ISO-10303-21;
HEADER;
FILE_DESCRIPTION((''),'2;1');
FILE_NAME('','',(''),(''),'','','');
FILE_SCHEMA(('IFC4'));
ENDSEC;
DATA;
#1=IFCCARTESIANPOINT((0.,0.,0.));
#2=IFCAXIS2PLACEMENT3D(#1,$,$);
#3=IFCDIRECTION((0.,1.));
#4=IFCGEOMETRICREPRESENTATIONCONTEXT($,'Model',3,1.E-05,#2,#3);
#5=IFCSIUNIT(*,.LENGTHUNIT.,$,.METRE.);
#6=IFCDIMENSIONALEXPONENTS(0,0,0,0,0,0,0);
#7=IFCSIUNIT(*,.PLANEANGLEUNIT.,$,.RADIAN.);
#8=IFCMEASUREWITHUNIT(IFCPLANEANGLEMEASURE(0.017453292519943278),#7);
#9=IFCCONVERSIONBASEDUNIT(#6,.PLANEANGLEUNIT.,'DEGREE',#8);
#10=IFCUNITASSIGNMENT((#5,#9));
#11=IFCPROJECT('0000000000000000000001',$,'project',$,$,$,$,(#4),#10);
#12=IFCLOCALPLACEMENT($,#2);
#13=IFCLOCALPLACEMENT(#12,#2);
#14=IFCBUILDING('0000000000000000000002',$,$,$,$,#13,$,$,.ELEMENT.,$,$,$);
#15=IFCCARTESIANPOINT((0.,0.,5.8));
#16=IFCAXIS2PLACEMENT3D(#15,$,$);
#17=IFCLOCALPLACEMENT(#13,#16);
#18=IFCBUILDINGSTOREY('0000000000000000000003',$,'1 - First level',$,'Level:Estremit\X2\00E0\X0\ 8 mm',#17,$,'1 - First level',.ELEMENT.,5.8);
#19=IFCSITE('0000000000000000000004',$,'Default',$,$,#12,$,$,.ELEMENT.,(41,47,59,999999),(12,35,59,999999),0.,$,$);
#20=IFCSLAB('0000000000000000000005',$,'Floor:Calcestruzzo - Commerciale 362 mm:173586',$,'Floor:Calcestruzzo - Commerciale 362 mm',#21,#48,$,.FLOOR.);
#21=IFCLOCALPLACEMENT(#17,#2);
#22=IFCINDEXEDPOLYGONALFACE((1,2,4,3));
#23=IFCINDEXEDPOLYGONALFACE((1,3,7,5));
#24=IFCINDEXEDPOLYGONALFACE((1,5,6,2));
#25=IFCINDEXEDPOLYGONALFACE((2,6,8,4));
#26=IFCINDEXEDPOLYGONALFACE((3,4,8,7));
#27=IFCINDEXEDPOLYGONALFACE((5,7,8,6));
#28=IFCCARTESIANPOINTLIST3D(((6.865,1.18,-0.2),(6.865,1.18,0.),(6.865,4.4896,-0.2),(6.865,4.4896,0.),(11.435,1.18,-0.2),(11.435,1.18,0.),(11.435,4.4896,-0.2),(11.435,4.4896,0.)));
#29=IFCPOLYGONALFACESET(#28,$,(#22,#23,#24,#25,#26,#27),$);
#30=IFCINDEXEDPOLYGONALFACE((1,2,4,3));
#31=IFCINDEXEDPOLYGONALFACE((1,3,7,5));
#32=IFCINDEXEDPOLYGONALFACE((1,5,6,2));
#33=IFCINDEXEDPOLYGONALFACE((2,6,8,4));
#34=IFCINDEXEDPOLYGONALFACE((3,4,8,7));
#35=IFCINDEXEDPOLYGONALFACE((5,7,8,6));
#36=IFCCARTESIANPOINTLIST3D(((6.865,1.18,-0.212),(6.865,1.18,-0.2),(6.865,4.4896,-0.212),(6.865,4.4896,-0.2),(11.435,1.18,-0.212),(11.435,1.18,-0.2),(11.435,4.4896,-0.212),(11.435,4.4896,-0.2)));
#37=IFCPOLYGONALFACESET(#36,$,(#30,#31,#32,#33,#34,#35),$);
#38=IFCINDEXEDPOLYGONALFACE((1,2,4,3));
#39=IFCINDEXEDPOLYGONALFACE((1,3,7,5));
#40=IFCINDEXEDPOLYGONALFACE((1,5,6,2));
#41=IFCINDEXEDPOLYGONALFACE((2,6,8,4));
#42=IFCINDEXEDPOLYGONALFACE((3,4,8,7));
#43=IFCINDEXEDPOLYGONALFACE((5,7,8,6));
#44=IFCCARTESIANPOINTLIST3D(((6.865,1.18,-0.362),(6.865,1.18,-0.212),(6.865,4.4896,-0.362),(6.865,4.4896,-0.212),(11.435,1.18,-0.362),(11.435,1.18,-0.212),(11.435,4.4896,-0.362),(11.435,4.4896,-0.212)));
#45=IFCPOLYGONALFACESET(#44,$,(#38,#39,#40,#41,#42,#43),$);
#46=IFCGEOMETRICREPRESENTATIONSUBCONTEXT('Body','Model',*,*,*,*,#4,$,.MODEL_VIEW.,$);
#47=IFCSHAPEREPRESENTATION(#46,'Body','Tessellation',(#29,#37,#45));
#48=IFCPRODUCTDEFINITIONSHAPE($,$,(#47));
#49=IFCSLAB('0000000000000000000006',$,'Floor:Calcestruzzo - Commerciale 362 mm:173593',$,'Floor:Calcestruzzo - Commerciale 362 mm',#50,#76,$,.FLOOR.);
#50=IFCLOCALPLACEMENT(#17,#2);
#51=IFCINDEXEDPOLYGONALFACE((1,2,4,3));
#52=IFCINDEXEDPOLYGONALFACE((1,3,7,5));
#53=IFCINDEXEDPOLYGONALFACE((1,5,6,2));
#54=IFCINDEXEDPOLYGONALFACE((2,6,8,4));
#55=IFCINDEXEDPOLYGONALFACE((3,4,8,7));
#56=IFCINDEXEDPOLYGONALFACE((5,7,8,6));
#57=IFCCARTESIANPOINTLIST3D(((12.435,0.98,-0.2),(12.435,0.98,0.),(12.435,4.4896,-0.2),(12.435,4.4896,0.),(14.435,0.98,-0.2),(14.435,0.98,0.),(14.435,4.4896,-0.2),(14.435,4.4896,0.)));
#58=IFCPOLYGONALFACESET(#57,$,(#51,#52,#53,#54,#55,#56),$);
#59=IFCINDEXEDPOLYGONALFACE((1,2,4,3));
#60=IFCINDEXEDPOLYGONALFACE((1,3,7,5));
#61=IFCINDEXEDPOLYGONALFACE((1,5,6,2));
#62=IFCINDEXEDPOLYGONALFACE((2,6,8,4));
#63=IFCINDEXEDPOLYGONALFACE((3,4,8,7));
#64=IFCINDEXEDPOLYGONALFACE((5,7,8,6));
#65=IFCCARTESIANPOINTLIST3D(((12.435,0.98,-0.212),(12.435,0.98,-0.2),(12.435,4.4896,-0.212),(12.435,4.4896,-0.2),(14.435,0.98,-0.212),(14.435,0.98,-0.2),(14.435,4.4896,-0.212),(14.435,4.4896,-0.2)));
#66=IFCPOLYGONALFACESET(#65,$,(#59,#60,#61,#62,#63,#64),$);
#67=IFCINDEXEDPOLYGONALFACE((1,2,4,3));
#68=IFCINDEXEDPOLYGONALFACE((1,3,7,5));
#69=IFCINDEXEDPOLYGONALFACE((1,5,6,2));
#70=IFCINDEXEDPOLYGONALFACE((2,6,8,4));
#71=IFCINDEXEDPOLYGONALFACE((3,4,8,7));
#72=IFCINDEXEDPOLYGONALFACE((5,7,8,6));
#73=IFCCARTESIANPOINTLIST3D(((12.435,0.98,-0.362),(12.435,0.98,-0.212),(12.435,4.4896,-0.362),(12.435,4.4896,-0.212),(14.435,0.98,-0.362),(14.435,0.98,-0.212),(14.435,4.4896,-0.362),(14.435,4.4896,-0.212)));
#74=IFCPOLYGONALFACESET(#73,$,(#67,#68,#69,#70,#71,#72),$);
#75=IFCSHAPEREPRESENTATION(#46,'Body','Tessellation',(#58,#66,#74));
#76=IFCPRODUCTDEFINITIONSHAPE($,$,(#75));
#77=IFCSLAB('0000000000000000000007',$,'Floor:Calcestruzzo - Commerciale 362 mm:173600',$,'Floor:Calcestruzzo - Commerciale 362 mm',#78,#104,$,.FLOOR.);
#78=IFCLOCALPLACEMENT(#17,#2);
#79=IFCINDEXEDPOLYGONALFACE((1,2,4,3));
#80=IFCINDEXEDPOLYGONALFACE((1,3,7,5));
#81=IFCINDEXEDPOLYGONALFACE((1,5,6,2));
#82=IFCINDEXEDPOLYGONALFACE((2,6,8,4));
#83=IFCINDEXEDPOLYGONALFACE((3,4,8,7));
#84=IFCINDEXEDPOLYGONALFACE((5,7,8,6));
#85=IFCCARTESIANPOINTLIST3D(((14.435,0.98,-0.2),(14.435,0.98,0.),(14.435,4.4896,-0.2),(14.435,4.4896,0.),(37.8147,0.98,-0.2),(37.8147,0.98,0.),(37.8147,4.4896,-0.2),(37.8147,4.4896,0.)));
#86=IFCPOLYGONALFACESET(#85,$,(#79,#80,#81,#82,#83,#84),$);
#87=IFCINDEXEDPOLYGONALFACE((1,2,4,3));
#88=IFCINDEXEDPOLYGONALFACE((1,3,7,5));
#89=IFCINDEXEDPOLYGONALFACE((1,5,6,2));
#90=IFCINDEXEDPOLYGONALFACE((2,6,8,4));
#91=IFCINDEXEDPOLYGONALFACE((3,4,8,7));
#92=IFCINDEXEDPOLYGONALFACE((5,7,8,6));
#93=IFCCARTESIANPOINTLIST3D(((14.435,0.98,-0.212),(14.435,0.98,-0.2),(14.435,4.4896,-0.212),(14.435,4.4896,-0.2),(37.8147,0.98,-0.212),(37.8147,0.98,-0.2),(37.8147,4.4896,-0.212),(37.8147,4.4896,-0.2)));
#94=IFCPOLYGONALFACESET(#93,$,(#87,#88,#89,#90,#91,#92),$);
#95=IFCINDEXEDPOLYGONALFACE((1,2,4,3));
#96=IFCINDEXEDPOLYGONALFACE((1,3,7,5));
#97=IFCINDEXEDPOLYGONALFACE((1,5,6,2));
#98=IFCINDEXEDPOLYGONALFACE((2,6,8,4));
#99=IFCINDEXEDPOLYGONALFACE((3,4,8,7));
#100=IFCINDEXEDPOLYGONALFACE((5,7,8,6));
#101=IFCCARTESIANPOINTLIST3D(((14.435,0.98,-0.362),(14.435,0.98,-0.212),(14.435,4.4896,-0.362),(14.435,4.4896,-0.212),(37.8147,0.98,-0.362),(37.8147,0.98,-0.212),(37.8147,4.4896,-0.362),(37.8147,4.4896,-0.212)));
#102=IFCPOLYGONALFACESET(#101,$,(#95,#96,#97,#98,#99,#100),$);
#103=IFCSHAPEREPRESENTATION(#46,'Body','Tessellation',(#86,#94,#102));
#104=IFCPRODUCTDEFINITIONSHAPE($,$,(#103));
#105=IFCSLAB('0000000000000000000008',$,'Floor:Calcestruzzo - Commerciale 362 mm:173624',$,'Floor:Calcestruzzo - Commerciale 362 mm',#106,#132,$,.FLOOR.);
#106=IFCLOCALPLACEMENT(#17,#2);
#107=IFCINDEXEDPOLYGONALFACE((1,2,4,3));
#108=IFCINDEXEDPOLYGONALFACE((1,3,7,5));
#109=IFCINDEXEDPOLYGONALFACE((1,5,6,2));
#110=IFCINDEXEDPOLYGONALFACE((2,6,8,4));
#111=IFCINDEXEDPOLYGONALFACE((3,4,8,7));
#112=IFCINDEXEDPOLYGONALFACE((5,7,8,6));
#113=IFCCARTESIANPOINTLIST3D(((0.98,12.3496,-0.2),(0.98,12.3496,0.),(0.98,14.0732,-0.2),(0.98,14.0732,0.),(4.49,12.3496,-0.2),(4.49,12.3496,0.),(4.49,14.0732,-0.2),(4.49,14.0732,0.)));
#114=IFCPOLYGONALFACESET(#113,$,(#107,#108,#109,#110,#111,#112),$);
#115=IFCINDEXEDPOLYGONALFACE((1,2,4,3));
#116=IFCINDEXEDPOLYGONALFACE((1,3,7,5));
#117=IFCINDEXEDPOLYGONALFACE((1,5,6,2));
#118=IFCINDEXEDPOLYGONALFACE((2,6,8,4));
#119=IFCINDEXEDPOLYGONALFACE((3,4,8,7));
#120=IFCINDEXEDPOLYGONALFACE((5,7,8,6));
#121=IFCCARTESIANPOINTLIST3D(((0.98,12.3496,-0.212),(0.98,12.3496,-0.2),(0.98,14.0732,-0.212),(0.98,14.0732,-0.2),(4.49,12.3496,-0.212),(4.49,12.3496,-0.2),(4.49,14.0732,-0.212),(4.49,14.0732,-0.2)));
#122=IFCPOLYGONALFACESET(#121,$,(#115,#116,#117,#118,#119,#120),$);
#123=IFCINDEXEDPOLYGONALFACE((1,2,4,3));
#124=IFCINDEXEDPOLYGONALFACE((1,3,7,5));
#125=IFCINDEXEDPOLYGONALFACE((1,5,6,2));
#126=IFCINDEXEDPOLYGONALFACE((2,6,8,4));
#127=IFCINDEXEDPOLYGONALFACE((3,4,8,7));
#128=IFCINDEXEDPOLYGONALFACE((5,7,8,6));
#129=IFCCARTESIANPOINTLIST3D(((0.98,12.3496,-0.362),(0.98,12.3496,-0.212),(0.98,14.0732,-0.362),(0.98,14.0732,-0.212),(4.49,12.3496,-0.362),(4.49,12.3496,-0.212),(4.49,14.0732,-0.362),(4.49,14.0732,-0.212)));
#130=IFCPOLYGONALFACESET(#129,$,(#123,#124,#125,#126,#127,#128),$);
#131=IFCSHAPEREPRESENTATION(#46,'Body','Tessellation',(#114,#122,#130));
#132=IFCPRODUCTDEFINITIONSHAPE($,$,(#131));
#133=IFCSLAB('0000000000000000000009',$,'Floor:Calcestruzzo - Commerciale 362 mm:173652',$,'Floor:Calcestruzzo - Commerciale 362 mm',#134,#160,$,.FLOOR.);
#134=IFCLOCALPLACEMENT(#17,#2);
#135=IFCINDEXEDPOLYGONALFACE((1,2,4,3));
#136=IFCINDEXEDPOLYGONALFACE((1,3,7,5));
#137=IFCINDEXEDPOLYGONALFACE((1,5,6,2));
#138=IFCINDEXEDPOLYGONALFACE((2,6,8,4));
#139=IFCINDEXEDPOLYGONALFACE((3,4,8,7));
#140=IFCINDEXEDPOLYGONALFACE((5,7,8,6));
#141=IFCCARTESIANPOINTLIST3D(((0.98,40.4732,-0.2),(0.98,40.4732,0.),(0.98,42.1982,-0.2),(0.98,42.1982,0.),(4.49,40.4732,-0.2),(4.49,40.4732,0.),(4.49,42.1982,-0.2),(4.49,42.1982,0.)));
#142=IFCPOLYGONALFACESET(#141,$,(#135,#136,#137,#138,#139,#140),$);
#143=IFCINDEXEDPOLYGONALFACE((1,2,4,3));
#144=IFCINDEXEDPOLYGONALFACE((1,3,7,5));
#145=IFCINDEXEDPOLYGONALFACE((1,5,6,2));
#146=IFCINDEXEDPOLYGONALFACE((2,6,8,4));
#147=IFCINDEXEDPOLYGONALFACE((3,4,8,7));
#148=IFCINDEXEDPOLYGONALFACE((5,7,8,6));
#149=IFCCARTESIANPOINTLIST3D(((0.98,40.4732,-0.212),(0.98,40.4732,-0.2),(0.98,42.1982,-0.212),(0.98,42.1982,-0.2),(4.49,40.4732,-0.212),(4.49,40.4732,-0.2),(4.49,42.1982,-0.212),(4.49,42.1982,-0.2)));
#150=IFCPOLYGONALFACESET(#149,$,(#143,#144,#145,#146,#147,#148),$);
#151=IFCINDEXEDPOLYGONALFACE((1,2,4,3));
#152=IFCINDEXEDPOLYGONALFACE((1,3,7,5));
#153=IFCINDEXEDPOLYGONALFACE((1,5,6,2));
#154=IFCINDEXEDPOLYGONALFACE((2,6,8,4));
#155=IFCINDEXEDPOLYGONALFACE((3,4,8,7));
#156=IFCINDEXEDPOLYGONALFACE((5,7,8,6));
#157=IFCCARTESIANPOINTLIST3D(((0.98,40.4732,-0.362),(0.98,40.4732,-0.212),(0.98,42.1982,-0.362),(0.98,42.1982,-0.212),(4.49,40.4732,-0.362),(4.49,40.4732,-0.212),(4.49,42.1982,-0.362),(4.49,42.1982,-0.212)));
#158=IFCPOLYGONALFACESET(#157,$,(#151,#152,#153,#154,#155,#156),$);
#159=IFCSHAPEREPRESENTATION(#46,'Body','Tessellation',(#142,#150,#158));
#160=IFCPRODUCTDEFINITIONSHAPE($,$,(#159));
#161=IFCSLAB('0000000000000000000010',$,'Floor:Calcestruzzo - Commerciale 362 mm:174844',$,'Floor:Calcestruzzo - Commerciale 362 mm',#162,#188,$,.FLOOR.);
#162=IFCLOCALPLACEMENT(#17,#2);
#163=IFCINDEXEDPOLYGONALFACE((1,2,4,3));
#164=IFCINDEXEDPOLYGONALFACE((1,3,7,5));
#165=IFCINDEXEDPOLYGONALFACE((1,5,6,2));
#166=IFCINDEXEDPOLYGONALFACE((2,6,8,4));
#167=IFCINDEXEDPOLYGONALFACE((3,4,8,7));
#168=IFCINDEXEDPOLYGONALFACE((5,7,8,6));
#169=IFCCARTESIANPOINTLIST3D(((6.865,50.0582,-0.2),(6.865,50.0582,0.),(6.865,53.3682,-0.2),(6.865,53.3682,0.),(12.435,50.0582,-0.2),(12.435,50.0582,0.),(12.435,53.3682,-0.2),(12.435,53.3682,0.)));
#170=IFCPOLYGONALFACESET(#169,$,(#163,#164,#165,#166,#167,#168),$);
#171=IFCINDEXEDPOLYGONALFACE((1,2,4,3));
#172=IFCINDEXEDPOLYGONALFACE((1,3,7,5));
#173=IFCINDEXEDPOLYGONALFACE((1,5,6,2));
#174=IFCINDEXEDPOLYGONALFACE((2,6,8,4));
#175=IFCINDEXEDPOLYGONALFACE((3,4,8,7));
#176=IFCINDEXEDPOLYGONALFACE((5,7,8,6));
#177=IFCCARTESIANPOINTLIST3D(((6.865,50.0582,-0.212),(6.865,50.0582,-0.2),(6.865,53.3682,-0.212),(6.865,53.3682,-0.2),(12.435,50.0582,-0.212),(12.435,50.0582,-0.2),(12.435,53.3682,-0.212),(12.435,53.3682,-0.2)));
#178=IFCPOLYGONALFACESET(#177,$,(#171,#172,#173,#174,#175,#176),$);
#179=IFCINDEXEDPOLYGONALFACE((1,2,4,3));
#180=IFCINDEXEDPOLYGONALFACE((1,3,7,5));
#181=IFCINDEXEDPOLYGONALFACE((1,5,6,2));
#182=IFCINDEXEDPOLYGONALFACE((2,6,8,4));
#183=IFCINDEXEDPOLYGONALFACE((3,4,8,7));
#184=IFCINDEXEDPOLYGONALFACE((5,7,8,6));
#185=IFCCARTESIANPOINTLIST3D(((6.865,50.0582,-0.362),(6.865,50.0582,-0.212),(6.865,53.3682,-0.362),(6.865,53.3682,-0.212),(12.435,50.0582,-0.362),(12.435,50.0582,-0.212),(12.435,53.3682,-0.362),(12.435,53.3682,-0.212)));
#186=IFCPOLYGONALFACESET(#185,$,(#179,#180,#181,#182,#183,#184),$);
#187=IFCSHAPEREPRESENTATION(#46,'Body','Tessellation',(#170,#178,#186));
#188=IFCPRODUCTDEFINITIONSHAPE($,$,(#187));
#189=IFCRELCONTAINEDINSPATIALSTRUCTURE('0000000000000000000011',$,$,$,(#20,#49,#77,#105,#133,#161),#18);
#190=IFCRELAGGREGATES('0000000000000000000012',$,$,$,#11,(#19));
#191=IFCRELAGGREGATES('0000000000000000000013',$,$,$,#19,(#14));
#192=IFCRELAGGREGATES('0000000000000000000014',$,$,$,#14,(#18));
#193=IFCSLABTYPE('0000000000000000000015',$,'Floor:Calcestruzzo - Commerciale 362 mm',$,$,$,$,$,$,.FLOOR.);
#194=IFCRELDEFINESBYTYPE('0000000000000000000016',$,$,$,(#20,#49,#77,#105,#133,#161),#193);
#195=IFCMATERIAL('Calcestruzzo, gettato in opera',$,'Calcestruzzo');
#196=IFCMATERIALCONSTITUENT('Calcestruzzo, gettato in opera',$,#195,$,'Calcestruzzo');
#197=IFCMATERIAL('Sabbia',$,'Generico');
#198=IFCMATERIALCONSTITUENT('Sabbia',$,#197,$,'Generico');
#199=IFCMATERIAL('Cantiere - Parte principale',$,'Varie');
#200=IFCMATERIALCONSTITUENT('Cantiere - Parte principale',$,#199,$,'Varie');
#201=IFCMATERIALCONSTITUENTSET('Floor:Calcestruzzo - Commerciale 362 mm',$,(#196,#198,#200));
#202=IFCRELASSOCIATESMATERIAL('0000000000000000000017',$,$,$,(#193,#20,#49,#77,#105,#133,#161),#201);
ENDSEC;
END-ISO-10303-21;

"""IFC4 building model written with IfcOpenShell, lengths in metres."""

from ifc_helpers import new_model, entity, si_unit, converted_unit, direction, frame, origin, place, context, subcontext, project, spatial, indexed_curve, outline, extrude, material, constituent, constituent_set, type_object, element, save


model = new_model("IFC4")

# Units and contexts
model_context = context("Model", 3, precision=1e-05, world=origin(), true_north=direction((0.0, 1.0)))
body_context = subcontext(model_context, "Body", "Model", "MODEL_VIEW")
ifc_project = project(units=[si_unit("LENGTHUNIT", "METRE"), converted_unit("PLANEANGLEUNIT", "DEGREE", entity("IfcPlaneAngleMeasure", 0.017453292519943278), si_unit("PLANEANGLEUNIT", "RADIAN"), dimensions=[0, 0, 0, 0, 0, 0, 0])], contexts=[model_context])

# Site, building, storey
site_placement = place(None, origin())
site = spatial("IfcSite", under=ifc_project, at=site_placement, Name="Default", CompositionType="ELEMENT", RefLatitude=(41, 47, 59, 999999), RefLongitude=(12, 35, 59, 999999), RefElevation=0.0)
building_placement = place(site_placement, origin())
building = spatial("IfcBuilding", under=site, at=building_placement, CompositionType="ELEMENT")
storey_placement = place(building_placement, frame((0.0, 0.0, 5.8)))
storey = spatial("IfcBuildingStorey", under=building, at=storey_placement, Name="1 - First level", ObjectType="Level:Estremità 8 mm", LongName="1 - First level", CompositionType="ELEMENT", Elevation=5.8)

# Slabs
ifc_material_1 = material(Name="Calcestruzzo, gettato in opera", Category="Calcestruzzo")
ifc_constituent_1 = constituent(ifc_material_1, Name="Calcestruzzo, gettato in opera", Category="Calcestruzzo")
ifc_material_2 = material(Name="Sabbia", Category="Generico")
ifc_constituent_2 = constituent(ifc_material_2, Name="Sabbia", Category="Generico")
ifc_material_3 = material(Name="Cantiere - Parte principale", Category="Varie")
ifc_constituent_3 = constituent(ifc_material_3, Name="Cantiere - Parte principale", Category="Varie")
ifc_constituent_set = constituent_set(constituents=[ifc_constituent_1, ifc_constituent_2, ifc_constituent_3], Name="Floor:Calcestruzzo - Commerciale 362 mm")
slab_type = type_object("IfcSlabType", Name="Floor:Calcestruzzo - Commerciale 362 mm", PredefinedType="FLOOR", material=ifc_constituent_set)
slab_1_placement = place(storey_placement, origin())
element("IfcSlab", 1, at=slab_1_placement, inside=storey, type_object=slab_type, material=ifc_constituent_set, Name="Floor:Calcestruzzo - Commerciale 362 mm:173586", ObjectType="Floor:Calcestruzzo - Commerciale 362 mm", PredefinedType="FLOOR", context=body_context, shape_type="SweptSolid", body=[
    extrude(outline(indexed_curve([(-1.6548, -2.285), (1.6548, -2.285), (1.6548, 2.285), (-1.6548, 2.285), (-1.6548, -2.285)], self_intersect=False)), frame((9.15, 2.8348, -0.2), z_axis=(0.0, 0.0, 1.0), x_axis=(0.0, 1.0, 0.0)), (0.0, 0.0, 1.0), 0.2),
    extrude(outline(indexed_curve([(-1.6548, -2.285), (1.6548, -2.285), (1.6548, 2.285), (-1.6548, 2.285), (-1.6548, -2.285)], self_intersect=False)), frame((9.15, 2.8348, -0.212), z_axis=(0.0, 0.0, 1.0), x_axis=(0.0, 1.0, 0.0)), (0.0, 0.0, 1.0), 0.012),
    extrude(outline(indexed_curve([(-1.6548, -2.285), (1.6548, -2.285), (1.6548, 2.285), (-1.6548, 2.285), (-1.6548, -2.285)], self_intersect=False)), frame((9.15, 2.8348, -0.362), z_axis=(0.0, 0.0, 1.0), x_axis=(0.0, 1.0, 0.0)), (0.0, 0.0, 1.0), 0.15),
])
slab_2_placement = place(storey_placement, origin())
element("IfcSlab", 2, at=slab_2_placement, inside=storey, type_object=slab_type, material=ifc_constituent_set, Name="Floor:Calcestruzzo - Commerciale 362 mm:173593", ObjectType="Floor:Calcestruzzo - Commerciale 362 mm", PredefinedType="FLOOR", context=body_context, shape_type="SweptSolid", body=[
    extrude(outline(indexed_curve([(-1.7548, -1.0), (1.7548, -1.0), (1.7548, 1.0), (-1.7548, 1.0), (-1.7548, -1.0)], self_intersect=False)), frame((13.435, 2.7348, -0.2), z_axis=(0.0, 0.0, 1.0), x_axis=(0.0, 1.0, 0.0)), (0.0, 0.0, 1.0), 0.2),
    extrude(outline(indexed_curve([(-1.7548, -1.0), (1.7548, -1.0), (1.7548, 1.0), (-1.7548, 1.0), (-1.7548, -1.0)], self_intersect=False)), frame((13.435, 2.7348, -0.212), z_axis=(0.0, 0.0, 1.0), x_axis=(0.0, 1.0, 0.0)), (0.0, 0.0, 1.0), 0.012),
    extrude(outline(indexed_curve([(-1.7548, -1.0), (1.7548, -1.0), (1.7548, 1.0), (-1.7548, 1.0), (-1.7548, -1.0)], self_intersect=False)), frame((13.435, 2.7348, -0.362), z_axis=(0.0, 0.0, 1.0), x_axis=(0.0, 1.0, 0.0)), (0.0, 0.0, 1.0), 0.15),
])
slab_3_placement = place(storey_placement, origin())
element("IfcSlab", 3, at=slab_3_placement, inside=storey, type_object=slab_type, material=ifc_constituent_set, Name="Floor:Calcestruzzo - Commerciale 362 mm:173600", ObjectType="Floor:Calcestruzzo - Commerciale 362 mm", PredefinedType="FLOOR", context=body_context, shape_type="SweptSolid", body=[
    extrude(outline(indexed_curve([(-1.7548, -11.6898), (1.7548, -11.6898), (1.7548, 11.6898), (-1.7548, 11.6898), (-1.7548, -11.6898)], self_intersect=False)), frame((26.1249, 2.7348, -0.2), z_axis=(0.0, 0.0, 1.0), x_axis=(0.0, 1.0, 0.0)), (0.0, 0.0, 1.0), 0.2),
    extrude(outline(indexed_curve([(-1.7548, -11.6898), (1.7548, -11.6898), (1.7548, 11.6898), (-1.7548, 11.6898), (-1.7548, -11.6898)], self_intersect=False)), frame((26.1249, 2.7348, -0.212), z_axis=(0.0, 0.0, 1.0), x_axis=(0.0, 1.0, 0.0)), (0.0, 0.0, 1.0), 0.012),
    extrude(outline(indexed_curve([(-1.7548, -11.6898), (1.7548, -11.6898), (1.7548, 11.6898), (-1.7548, 11.6898), (-1.7548, -11.6898)], self_intersect=False)), frame((26.1249, 2.7348, -0.362), z_axis=(0.0, 0.0, 1.0), x_axis=(0.0, 1.0, 0.0)), (0.0, 0.0, 1.0), 0.15),
])
slab_4_placement = place(storey_placement, origin())
element("IfcSlab", 4, at=slab_4_placement, inside=storey, type_object=slab_type, material=ifc_constituent_set, Name="Floor:Calcestruzzo - Commerciale 362 mm:173624", ObjectType="Floor:Calcestruzzo - Commerciale 362 mm", PredefinedType="FLOOR", context=body_context, shape_type="SweptSolid", body=[
    extrude(outline(indexed_curve([(-0.8618, -1.755), (0.8618, -1.755), (0.8618, 1.755), (-0.8618, 1.755), (-0.8618, -1.755)], self_intersect=False)), frame((2.735, 13.2114, -0.2), z_axis=(0.0, 0.0, 1.0), x_axis=(0.0, -1.0, 0.0)), (0.0, 0.0, 1.0), 0.2),
    extrude(outline(indexed_curve([(-0.8618, -1.755), (0.8618, -1.755), (0.8618, 1.755), (-0.8618, 1.755), (-0.8618, -1.755)], self_intersect=False)), frame((2.735, 13.2114, -0.212), z_axis=(0.0, 0.0, 1.0), x_axis=(0.0, -1.0, 0.0)), (0.0, 0.0, 1.0), 0.012),
    extrude(outline(indexed_curve([(-0.8618, -1.755), (0.8618, -1.755), (0.8618, 1.755), (-0.8618, 1.755), (-0.8618, -1.755)], self_intersect=False)), frame((2.735, 13.2114, -0.362), z_axis=(0.0, 0.0, 1.0), x_axis=(0.0, -1.0, 0.0)), (0.0, 0.0, 1.0), 0.15),
])
slab_5_placement = place(storey_placement, origin())
element("IfcSlab", 5, at=slab_5_placement, inside=storey, type_object=slab_type, material=ifc_constituent_set, Name="Floor:Calcestruzzo - Commerciale 362 mm:173652", ObjectType="Floor:Calcestruzzo - Commerciale 362 mm", PredefinedType="FLOOR", context=body_context, shape_type="SweptSolid", body=[
    extrude(outline(indexed_curve([(-1.755, -0.8625), (1.755, -0.8625), (1.755, 0.8625), (-1.755, 0.8625), (-1.755, -0.8625)], self_intersect=False)), frame((2.735, 41.3357, -0.2)), (0.0, 0.0, 1.0), 0.2),
    extrude(outline(indexed_curve([(-1.755, -0.8625), (1.755, -0.8625), (1.755, 0.8625), (-1.755, 0.8625), (-1.755, -0.8625)], self_intersect=False)), frame((2.735, 41.3357, -0.212)), (0.0, 0.0, 1.0), 0.012),
    extrude(outline(indexed_curve([(-1.755, -0.8625), (1.755, -0.8625), (1.755, 0.8625), (-1.755, 0.8625), (-1.755, -0.8625)], self_intersect=False)), frame((2.735, 41.3357, -0.362)), (0.0, 0.0, 1.0), 0.15),
])
slab_6_placement = place(storey_placement, origin())
element("IfcSlab", 6, at=slab_6_placement, inside=storey, type_object=slab_type, material=ifc_constituent_set, Name="Floor:Calcestruzzo - Commerciale 362 mm:174844", ObjectType="Floor:Calcestruzzo - Commerciale 362 mm", PredefinedType="FLOOR", context=body_context, shape_type="SweptSolid", body=[
    extrude(outline(indexed_curve([(-2.785, -1.655), (2.785, -1.655), (2.785, 1.655), (-2.785, 1.655), (-2.785, -1.655)], self_intersect=False)), frame((9.65, 51.7132, -0.2), z_axis=(0.0, 0.0, 1.0), x_axis=(-1.0, 0.0, 0.0)), (0.0, 0.0, 1.0), 0.2),
    extrude(outline(indexed_curve([(-2.785, -1.655), (2.785, -1.655), (2.785, 1.655), (-2.785, 1.655), (-2.785, -1.655)], self_intersect=False)), frame((9.65, 51.7132, -0.212), z_axis=(0.0, 0.0, 1.0), x_axis=(-1.0, 0.0, 0.0)), (0.0, 0.0, 1.0), 0.012),
    extrude(outline(indexed_curve([(-2.785, -1.655), (2.785, -1.655), (2.785, 1.655), (-2.785, 1.655), (-2.785, -1.655)], self_intersect=False)), frame((9.65, 51.7132, -0.362), z_axis=(0.0, 0.0, 1.0), x_axis=(-1.0, 0.0, 0.0)), (0.0, 0.0, 1.0), 0.15),
])

save(model, "model.ifc")
